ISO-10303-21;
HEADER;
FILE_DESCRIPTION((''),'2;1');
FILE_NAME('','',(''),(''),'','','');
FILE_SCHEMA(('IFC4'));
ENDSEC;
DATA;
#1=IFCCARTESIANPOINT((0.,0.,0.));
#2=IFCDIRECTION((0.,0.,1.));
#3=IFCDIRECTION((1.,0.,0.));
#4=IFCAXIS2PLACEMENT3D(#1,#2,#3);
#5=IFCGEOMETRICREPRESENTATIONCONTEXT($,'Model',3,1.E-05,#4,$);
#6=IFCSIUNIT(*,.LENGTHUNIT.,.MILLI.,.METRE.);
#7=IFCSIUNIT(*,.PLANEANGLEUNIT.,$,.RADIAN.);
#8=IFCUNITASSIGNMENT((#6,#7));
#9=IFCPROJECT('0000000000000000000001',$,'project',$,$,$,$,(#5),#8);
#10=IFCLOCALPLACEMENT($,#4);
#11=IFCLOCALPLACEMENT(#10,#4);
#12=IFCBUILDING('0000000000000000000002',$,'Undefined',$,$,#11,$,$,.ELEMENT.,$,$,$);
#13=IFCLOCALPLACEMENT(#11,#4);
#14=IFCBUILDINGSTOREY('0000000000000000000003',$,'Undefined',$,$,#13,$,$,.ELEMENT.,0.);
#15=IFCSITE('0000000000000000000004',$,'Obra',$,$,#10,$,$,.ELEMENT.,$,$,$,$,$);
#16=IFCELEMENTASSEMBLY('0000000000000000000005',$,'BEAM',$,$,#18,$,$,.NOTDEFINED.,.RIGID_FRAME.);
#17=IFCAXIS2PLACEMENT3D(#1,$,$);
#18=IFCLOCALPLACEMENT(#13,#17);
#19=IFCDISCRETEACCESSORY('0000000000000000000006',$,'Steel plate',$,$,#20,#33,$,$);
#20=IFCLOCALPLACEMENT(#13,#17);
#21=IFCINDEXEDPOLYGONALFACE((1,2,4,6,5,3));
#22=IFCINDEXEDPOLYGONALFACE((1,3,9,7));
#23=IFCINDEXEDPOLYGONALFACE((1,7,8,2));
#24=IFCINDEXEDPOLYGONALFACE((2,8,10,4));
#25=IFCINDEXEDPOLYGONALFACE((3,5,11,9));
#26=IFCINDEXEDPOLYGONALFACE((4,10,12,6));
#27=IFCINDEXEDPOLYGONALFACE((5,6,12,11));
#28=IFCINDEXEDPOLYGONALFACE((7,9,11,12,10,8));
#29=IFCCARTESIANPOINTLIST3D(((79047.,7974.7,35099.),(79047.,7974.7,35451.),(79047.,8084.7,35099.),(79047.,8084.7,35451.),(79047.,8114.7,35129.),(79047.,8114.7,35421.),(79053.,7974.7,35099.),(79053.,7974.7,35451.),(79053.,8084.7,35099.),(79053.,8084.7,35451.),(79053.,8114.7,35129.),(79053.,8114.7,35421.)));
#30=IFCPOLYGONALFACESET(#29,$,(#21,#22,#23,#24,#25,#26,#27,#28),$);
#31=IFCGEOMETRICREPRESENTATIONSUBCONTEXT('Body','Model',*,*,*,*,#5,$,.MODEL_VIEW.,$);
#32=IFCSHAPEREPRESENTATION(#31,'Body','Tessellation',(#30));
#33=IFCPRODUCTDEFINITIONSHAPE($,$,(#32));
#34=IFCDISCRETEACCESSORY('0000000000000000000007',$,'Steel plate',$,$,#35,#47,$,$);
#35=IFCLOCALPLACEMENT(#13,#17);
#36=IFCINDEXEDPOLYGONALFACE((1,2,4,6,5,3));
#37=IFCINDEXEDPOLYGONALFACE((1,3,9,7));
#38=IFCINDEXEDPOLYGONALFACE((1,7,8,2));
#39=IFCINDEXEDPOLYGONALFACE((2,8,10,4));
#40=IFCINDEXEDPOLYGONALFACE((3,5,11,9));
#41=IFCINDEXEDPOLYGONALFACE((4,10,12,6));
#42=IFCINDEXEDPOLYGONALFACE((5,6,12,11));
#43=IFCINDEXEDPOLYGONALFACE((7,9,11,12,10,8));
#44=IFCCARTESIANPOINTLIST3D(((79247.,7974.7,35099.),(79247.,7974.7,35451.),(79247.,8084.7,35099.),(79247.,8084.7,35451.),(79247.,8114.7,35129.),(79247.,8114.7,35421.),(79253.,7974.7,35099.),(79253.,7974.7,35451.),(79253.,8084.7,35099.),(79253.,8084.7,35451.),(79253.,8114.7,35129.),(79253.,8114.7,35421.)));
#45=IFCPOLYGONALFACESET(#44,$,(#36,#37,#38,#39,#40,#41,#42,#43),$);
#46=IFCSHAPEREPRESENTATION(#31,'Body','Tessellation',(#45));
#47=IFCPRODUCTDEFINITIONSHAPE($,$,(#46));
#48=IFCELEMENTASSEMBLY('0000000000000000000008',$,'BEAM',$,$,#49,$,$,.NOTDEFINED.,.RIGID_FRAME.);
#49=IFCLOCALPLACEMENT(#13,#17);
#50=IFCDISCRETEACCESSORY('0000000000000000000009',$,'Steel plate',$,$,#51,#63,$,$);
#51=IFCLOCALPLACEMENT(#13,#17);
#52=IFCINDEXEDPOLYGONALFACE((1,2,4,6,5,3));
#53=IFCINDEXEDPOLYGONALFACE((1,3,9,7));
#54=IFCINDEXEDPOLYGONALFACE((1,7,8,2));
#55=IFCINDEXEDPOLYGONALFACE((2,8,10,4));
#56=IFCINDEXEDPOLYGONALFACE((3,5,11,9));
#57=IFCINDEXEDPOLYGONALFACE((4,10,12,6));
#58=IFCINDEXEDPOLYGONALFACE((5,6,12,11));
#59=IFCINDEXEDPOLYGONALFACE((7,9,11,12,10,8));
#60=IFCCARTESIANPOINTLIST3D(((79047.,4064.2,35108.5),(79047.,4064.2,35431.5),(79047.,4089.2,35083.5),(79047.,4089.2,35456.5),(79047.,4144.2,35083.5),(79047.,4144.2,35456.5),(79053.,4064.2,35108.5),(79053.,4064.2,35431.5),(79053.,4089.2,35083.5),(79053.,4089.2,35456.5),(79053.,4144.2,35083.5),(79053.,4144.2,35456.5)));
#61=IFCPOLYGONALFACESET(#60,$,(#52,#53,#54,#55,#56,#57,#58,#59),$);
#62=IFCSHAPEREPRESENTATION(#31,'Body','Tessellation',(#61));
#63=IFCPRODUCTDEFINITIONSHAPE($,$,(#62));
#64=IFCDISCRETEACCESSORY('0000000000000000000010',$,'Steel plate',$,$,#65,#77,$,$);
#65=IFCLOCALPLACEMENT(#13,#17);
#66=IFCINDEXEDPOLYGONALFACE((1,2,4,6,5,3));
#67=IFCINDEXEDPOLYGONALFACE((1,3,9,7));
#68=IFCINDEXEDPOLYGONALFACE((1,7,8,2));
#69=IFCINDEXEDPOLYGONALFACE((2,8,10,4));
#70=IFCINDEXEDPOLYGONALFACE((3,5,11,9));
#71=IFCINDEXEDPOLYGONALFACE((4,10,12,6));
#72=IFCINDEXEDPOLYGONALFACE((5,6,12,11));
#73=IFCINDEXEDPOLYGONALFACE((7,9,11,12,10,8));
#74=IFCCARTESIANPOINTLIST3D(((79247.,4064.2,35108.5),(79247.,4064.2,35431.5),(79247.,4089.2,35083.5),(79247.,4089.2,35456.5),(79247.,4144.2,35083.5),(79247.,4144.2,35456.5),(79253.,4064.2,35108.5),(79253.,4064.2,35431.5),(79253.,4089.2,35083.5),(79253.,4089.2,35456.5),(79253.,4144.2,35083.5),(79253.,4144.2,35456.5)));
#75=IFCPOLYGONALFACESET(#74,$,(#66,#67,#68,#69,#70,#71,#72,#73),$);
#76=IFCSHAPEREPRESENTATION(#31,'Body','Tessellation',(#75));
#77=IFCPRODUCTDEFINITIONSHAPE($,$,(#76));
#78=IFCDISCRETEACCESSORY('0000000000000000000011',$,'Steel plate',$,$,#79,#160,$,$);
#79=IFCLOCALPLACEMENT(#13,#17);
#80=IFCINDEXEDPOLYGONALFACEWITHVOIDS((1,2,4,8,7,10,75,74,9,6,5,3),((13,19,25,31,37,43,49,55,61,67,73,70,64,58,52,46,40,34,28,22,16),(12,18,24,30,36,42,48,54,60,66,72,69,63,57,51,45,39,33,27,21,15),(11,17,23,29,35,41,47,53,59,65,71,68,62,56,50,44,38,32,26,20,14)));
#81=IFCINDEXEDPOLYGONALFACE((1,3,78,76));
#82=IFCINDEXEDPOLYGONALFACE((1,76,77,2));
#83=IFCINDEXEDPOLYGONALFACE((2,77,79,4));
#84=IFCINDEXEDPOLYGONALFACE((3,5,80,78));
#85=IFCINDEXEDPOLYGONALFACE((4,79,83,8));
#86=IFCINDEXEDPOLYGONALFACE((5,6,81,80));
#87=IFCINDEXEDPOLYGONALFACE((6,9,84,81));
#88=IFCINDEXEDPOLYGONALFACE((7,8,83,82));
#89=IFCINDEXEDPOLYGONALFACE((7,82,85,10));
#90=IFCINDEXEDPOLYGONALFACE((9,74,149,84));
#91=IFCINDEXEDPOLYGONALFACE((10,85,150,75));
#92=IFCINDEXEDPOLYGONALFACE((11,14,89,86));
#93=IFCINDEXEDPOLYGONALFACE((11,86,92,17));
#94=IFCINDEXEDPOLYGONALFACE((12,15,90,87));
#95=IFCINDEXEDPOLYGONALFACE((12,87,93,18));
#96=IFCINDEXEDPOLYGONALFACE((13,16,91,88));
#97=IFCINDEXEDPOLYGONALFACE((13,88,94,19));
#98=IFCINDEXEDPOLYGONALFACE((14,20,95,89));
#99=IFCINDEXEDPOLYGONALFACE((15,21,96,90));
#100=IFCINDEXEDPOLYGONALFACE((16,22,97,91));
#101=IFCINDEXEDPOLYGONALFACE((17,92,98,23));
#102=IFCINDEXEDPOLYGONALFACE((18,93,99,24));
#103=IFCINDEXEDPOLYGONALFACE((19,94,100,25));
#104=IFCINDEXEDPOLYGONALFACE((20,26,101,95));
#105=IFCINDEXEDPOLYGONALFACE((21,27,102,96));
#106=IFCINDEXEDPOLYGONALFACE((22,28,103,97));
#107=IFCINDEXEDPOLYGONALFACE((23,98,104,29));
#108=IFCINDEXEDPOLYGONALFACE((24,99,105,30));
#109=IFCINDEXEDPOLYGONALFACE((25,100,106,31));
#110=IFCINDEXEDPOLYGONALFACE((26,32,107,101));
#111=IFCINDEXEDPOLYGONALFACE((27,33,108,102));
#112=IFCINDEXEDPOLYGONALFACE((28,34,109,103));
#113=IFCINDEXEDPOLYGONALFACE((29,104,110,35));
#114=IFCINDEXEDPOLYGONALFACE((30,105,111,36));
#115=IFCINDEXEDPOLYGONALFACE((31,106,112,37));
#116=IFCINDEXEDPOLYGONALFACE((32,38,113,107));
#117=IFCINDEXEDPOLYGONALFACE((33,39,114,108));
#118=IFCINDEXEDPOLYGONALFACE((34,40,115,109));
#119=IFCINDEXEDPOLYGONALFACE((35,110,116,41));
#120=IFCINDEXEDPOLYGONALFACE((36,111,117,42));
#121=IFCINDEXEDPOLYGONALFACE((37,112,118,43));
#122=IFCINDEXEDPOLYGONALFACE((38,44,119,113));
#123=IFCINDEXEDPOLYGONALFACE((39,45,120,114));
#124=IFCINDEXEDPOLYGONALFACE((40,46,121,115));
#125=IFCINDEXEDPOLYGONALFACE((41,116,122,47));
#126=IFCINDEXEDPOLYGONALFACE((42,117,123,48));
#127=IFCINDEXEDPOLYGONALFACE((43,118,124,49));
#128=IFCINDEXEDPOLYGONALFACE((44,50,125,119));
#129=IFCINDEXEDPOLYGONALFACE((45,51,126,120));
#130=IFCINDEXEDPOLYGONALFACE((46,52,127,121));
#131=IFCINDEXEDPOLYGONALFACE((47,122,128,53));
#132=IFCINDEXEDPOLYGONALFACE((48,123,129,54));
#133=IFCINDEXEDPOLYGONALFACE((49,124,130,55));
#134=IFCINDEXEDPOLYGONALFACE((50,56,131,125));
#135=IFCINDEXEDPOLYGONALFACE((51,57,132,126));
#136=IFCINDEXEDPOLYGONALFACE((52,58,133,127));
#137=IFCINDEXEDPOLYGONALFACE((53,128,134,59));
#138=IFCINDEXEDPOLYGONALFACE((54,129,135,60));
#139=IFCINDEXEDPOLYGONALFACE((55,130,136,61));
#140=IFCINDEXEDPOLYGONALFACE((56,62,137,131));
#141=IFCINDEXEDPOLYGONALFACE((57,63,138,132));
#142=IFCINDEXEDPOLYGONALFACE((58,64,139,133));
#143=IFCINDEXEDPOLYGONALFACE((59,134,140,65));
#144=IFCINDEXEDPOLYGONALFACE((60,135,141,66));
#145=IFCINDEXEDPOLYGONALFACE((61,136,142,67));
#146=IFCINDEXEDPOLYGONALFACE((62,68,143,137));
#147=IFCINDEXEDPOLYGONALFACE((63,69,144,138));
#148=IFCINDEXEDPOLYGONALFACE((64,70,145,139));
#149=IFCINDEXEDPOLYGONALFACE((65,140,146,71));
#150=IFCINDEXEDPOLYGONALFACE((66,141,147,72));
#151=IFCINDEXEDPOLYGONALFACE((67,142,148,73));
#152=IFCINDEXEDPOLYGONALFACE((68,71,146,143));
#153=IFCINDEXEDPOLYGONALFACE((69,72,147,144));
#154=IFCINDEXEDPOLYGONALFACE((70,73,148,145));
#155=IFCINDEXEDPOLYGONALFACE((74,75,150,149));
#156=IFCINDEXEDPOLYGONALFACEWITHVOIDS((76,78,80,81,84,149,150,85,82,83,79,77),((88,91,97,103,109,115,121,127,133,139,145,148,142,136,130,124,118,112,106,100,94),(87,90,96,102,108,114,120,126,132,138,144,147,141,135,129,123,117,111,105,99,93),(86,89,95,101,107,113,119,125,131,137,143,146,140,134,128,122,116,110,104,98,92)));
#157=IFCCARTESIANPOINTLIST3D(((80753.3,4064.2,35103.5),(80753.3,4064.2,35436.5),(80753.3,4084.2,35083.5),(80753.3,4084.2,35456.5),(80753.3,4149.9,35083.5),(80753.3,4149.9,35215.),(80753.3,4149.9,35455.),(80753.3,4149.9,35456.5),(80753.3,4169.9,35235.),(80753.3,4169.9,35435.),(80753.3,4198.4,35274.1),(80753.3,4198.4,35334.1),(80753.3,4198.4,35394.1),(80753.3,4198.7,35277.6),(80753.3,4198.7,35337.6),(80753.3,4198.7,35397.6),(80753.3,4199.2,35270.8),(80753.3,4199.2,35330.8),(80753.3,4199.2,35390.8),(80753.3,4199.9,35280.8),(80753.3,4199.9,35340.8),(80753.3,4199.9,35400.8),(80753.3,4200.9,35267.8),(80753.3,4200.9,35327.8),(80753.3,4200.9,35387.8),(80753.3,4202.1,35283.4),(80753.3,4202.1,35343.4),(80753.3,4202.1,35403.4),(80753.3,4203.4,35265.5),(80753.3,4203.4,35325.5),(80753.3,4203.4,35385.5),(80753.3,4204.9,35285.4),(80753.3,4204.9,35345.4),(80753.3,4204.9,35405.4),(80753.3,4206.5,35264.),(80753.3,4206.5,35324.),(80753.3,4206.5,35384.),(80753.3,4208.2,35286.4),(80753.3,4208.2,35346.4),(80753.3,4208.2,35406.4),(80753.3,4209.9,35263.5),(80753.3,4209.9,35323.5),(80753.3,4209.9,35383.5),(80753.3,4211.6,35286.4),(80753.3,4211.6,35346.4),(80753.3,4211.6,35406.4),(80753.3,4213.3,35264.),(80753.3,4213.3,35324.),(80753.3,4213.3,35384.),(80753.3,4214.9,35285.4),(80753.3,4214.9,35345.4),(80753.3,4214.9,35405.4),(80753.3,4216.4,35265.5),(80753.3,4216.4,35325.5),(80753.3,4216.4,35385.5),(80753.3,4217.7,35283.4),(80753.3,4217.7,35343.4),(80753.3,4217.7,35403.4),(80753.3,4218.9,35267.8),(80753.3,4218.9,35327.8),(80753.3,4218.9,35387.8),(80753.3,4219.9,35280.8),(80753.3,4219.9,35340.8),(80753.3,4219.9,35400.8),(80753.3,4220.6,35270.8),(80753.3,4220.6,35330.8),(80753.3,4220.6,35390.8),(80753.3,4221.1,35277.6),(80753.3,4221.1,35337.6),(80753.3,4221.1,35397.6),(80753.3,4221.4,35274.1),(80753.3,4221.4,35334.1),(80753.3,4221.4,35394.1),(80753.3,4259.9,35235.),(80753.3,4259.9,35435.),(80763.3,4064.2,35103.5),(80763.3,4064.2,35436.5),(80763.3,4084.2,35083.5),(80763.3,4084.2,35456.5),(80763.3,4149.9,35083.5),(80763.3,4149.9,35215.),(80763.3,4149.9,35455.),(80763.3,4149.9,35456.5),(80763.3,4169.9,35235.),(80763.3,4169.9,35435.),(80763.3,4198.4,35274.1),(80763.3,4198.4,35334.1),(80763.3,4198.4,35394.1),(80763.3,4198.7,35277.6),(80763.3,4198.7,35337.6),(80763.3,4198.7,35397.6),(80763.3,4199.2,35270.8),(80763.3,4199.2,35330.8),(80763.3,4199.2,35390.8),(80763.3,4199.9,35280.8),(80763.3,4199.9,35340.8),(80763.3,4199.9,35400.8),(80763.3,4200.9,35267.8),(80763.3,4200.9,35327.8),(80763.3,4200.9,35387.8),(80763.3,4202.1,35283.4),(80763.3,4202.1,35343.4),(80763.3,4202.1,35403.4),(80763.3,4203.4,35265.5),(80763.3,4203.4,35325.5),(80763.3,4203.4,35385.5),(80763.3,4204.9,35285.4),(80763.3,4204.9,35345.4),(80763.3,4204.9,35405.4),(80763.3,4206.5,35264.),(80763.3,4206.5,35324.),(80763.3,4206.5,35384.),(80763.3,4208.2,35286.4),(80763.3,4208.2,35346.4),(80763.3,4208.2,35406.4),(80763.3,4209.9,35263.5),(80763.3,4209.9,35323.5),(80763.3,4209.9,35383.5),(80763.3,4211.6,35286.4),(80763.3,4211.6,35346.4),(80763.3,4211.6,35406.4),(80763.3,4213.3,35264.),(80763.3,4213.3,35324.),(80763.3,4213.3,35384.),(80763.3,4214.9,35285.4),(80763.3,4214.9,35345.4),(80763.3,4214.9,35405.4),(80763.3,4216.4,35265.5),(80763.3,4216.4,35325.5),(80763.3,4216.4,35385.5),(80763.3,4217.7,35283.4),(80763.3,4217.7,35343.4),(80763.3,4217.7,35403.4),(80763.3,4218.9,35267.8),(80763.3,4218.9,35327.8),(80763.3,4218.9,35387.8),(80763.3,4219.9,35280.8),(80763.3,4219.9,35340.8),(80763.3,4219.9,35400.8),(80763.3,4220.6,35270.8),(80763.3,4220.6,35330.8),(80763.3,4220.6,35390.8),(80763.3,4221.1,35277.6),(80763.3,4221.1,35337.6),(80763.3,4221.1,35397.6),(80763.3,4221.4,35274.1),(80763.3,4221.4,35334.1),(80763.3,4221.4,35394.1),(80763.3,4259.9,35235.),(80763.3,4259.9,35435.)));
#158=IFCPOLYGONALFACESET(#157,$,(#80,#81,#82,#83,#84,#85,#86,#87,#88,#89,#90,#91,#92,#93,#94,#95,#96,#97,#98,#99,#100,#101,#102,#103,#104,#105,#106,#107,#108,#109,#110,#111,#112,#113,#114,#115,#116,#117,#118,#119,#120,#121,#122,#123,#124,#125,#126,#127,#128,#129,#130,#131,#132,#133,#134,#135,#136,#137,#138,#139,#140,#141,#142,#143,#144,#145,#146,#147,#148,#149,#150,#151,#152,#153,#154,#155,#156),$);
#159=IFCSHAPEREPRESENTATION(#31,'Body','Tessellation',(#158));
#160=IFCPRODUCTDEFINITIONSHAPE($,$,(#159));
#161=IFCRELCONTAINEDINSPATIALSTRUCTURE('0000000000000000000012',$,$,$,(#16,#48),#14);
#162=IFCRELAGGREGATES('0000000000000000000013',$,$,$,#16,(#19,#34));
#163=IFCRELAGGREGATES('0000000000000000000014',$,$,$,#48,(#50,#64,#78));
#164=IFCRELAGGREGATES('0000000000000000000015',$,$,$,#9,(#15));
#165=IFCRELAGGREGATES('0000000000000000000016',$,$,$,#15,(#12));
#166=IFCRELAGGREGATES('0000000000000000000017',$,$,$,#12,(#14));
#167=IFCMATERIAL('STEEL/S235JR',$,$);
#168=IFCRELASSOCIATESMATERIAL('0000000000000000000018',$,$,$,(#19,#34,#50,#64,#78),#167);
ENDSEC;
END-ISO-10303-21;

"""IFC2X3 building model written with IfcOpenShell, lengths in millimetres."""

from ifc_helpers import new_model, si_unit, frame, origin_with_axes, origin_2d_with_axis, place, context, subcontext, project, spatial, polyline, circle, outline, extrude, source, transform, mapped, material, element, aggregate, save


model = new_model("IFC2X3")

# Units and contexts
model_context = context("Model", 3, precision=1e-05, world=origin_with_axes())
body_context = subcontext(model_context, "Body", "Model", "MODEL_VIEW")
ifc_project = project(units=[si_unit("LENGTHUNIT", "METRE", prefix="MILLI"), si_unit("PLANEANGLEUNIT", "RADIAN")], contexts=[model_context])

# Site, building, storey
site_placement = place(None, origin_with_axes())
site = spatial("IfcSite", under=ifc_project, at=site_placement, Name="Obra", CompositionType="ELEMENT")
building_placement = place(site_placement, origin_with_axes())
building = spatial("IfcBuilding", under=site, at=building_placement, Name="Undefined", CompositionType="ELEMENT")
storey_placement = place(building_placement, origin_with_axes())
storey = spatial("IfcBuildingStorey", under=building, at=storey_placement, Name="Undefined", CompositionType="ELEMENT", Elevation=0.0)

# Shared definitions
ifc_material_1 = material(Name="STEEL/S235JR")

# Element assembly, discrete accessories
assembly_1_placement = place(storey_placement, origin_with_axes())
assembly_1 = element("IfcElementAssembly", 1, at=assembly_1_placement, inside=storey, Name="BEAM", AssemblyPlace="NOTDEFINED", PredefinedType="RIGID_FRAME")
discrete_accessory_1_placement = place(assembly_1_placement, frame((79050.0, 7974.7, 35099.0), z_axis=(1.0, 0.0, 0.0), x_axis=(0.0, 1.0, 0.0)))
discrete_accessory_1 = element("IfcDiscreteAccessory", 2, at=discrete_accessory_1_placement, material=ifc_material_1, Name="Steel plate", context=body_context, shape_type="SweptSolid", body=[
    extrude(outline(polyline([(0.0, 0.0), (110.0, 0.0), (140.0, 30.0), (140.0, 322.0), (110.0, 352.0), (0.0, 352.0), (0.0, 0.0)])), frame((0.0, 0.0, -3.0), z_axis=(0.0, 0.0, 1.0), x_axis=(1.0, 0.0, 0.0)), (0.0, 0.0, 1.0), 6.0),
])
discrete_accessory_2_placement = place(assembly_1_placement, frame((79250.0, 7974.7, 35099.0), z_axis=(1.0, 0.0, 0.0), x_axis=(0.0, 1.0, 0.0)))
discrete_accessory_2 = element("IfcDiscreteAccessory", 3, at=discrete_accessory_2_placement, material=ifc_material_1, Name="Steel plate", context=body_context, shape_type="SweptSolid", body=[
    extrude(outline(polyline([(0.0, 0.0), (110.0, 0.0), (140.0, 30.0), (140.0, 322.0), (110.0, 352.0), (0.0, 352.0), (0.0, 0.0)])), frame((0.0, 0.0, -3.0), z_axis=(0.0, 0.0, 1.0), x_axis=(1.0, 0.0, 0.0)), (0.0, 0.0, 1.0), 6.0),
])
aggregate(assembly_1, [discrete_accessory_1, discrete_accessory_2])

# Element assembly, discrete accessories, opening
assembly_2_placement = place(storey_placement, origin_with_axes())
assembly_2 = element("IfcElementAssembly", 4, at=assembly_2_placement, inside=storey, Name="BEAM", AssemblyPlace="NOTDEFINED", PredefinedType="RIGID_FRAME")
discrete_accessory_3_placement = place(assembly_2_placement, frame((79050.0, 4064.2, 35083.5), z_axis=(1.0, 0.0, 0.0), x_axis=(0.0, 1.0, 0.0)))
discrete_accessory_3 = element("IfcDiscreteAccessory", 5, at=discrete_accessory_3_placement, material=ifc_material_1, Name="Steel plate", context=body_context, shape_type="SweptSolid", body=[
    extrude(outline(polyline([(0.0, 25.0), (25.0, 0.0), (80.0, 0.0), (80.0, 373.0), (25.0, 373.0), (0.0, 348.0), (0.0, 25.0)])), frame((0.0, 0.0, -3.0), z_axis=(0.0, 0.0, 1.0), x_axis=(1.0, 0.0, 0.0)), (0.0, 0.0, 1.0), 6.0),
])
discrete_accessory_4_placement = place(assembly_2_placement, frame((79250.0, 4064.2, 35083.5), z_axis=(1.0, 0.0, 0.0), x_axis=(0.0, 1.0, 0.0)))
discrete_accessory_4 = element("IfcDiscreteAccessory", 6, at=discrete_accessory_4_placement, material=ifc_material_1, Name="Steel plate", context=body_context, shape_type="SweptSolid", body=[
    extrude(outline(polyline([(0.0, 25.0), (25.0, 0.0), (80.0, 0.0), (80.0, 373.0), (25.0, 373.0), (0.0, 348.0), (0.0, 25.0)])), frame((0.0, 0.0, -3.0), z_axis=(0.0, 0.0, 1.0), x_axis=(1.0, 0.0, 0.0)), (0.0, 0.0, 1.0), 6.0),
])
discrete_accessory_5_placement = place(assembly_2_placement, frame((80758.3, 4064.2, 35103.5), z_axis=(1.0, 0.0, 0.0), x_axis=(0.0, 0.707107, -0.707107)))
discrete_accessory_5 = element("IfcDiscreteAccessory", 7, at=discrete_accessory_5_placement, material=ifc_material_1, Name="Steel plate", context=body_context, shape_type="SweptSolid", body=[
    extrude(outline(polyline([(0.0, 0.0), (28.3, 0.0), (74.7, 46.5), (-18.2, 139.4), (-18.2, 167.7), (45.4, 231.4), (-96.0, 372.8), (-159.7, 309.1), (-187.9, 309.1), (-189.0, 310.2), (-235.5, 263.8), (-235.5, 235.5), (0.0, 0.0)])), frame((0.0, 0.0, -5.0), z_axis=(0.0, 0.0, 1.0), x_axis=(1.0, 0.0, 0.0)), (0.0, 0.0, 1.0), 10.0),
])
shared_shape_1 = source(origin_with_axes(), body_context, "Body", "SweptSolid", [
    extrude(circle(Radius=11.5, at=origin_2d_with_axis()), frame((0.0, -13.4, 0.0), z_axis=(0.0, 1.0, 0.0), x_axis=(1.0, 0.0, 0.0)), (0.0, 0.0, 1.0), 10.2),
])
opening_1_placement = place(assembly_2_placement, frame((80750.0, 4159.9, 35435.0), z_axis=(0.0, 1.0, 0.0), x_axis=(0.0, 0.0, -1.0)))
element("IfcOpeningElement", 8, at=opening_1_placement, cuts=discrete_accessory_5, ObjectType="Opening", context=body_context, shape_type="MappedRepresentation", body=[
    mapped(shared_shape_1, transform((40.0, 0.0, 50.0))),
    mapped(shared_shape_1, transform((100.0, 0.0, 50.0))),
    mapped(shared_shape_1, transform((160.0, 0.0, 50.0))),
])
aggregate(assembly_2, [discrete_accessory_3, discrete_accessory_4, discrete_accessory_5])

save(model, "model.ifc")
